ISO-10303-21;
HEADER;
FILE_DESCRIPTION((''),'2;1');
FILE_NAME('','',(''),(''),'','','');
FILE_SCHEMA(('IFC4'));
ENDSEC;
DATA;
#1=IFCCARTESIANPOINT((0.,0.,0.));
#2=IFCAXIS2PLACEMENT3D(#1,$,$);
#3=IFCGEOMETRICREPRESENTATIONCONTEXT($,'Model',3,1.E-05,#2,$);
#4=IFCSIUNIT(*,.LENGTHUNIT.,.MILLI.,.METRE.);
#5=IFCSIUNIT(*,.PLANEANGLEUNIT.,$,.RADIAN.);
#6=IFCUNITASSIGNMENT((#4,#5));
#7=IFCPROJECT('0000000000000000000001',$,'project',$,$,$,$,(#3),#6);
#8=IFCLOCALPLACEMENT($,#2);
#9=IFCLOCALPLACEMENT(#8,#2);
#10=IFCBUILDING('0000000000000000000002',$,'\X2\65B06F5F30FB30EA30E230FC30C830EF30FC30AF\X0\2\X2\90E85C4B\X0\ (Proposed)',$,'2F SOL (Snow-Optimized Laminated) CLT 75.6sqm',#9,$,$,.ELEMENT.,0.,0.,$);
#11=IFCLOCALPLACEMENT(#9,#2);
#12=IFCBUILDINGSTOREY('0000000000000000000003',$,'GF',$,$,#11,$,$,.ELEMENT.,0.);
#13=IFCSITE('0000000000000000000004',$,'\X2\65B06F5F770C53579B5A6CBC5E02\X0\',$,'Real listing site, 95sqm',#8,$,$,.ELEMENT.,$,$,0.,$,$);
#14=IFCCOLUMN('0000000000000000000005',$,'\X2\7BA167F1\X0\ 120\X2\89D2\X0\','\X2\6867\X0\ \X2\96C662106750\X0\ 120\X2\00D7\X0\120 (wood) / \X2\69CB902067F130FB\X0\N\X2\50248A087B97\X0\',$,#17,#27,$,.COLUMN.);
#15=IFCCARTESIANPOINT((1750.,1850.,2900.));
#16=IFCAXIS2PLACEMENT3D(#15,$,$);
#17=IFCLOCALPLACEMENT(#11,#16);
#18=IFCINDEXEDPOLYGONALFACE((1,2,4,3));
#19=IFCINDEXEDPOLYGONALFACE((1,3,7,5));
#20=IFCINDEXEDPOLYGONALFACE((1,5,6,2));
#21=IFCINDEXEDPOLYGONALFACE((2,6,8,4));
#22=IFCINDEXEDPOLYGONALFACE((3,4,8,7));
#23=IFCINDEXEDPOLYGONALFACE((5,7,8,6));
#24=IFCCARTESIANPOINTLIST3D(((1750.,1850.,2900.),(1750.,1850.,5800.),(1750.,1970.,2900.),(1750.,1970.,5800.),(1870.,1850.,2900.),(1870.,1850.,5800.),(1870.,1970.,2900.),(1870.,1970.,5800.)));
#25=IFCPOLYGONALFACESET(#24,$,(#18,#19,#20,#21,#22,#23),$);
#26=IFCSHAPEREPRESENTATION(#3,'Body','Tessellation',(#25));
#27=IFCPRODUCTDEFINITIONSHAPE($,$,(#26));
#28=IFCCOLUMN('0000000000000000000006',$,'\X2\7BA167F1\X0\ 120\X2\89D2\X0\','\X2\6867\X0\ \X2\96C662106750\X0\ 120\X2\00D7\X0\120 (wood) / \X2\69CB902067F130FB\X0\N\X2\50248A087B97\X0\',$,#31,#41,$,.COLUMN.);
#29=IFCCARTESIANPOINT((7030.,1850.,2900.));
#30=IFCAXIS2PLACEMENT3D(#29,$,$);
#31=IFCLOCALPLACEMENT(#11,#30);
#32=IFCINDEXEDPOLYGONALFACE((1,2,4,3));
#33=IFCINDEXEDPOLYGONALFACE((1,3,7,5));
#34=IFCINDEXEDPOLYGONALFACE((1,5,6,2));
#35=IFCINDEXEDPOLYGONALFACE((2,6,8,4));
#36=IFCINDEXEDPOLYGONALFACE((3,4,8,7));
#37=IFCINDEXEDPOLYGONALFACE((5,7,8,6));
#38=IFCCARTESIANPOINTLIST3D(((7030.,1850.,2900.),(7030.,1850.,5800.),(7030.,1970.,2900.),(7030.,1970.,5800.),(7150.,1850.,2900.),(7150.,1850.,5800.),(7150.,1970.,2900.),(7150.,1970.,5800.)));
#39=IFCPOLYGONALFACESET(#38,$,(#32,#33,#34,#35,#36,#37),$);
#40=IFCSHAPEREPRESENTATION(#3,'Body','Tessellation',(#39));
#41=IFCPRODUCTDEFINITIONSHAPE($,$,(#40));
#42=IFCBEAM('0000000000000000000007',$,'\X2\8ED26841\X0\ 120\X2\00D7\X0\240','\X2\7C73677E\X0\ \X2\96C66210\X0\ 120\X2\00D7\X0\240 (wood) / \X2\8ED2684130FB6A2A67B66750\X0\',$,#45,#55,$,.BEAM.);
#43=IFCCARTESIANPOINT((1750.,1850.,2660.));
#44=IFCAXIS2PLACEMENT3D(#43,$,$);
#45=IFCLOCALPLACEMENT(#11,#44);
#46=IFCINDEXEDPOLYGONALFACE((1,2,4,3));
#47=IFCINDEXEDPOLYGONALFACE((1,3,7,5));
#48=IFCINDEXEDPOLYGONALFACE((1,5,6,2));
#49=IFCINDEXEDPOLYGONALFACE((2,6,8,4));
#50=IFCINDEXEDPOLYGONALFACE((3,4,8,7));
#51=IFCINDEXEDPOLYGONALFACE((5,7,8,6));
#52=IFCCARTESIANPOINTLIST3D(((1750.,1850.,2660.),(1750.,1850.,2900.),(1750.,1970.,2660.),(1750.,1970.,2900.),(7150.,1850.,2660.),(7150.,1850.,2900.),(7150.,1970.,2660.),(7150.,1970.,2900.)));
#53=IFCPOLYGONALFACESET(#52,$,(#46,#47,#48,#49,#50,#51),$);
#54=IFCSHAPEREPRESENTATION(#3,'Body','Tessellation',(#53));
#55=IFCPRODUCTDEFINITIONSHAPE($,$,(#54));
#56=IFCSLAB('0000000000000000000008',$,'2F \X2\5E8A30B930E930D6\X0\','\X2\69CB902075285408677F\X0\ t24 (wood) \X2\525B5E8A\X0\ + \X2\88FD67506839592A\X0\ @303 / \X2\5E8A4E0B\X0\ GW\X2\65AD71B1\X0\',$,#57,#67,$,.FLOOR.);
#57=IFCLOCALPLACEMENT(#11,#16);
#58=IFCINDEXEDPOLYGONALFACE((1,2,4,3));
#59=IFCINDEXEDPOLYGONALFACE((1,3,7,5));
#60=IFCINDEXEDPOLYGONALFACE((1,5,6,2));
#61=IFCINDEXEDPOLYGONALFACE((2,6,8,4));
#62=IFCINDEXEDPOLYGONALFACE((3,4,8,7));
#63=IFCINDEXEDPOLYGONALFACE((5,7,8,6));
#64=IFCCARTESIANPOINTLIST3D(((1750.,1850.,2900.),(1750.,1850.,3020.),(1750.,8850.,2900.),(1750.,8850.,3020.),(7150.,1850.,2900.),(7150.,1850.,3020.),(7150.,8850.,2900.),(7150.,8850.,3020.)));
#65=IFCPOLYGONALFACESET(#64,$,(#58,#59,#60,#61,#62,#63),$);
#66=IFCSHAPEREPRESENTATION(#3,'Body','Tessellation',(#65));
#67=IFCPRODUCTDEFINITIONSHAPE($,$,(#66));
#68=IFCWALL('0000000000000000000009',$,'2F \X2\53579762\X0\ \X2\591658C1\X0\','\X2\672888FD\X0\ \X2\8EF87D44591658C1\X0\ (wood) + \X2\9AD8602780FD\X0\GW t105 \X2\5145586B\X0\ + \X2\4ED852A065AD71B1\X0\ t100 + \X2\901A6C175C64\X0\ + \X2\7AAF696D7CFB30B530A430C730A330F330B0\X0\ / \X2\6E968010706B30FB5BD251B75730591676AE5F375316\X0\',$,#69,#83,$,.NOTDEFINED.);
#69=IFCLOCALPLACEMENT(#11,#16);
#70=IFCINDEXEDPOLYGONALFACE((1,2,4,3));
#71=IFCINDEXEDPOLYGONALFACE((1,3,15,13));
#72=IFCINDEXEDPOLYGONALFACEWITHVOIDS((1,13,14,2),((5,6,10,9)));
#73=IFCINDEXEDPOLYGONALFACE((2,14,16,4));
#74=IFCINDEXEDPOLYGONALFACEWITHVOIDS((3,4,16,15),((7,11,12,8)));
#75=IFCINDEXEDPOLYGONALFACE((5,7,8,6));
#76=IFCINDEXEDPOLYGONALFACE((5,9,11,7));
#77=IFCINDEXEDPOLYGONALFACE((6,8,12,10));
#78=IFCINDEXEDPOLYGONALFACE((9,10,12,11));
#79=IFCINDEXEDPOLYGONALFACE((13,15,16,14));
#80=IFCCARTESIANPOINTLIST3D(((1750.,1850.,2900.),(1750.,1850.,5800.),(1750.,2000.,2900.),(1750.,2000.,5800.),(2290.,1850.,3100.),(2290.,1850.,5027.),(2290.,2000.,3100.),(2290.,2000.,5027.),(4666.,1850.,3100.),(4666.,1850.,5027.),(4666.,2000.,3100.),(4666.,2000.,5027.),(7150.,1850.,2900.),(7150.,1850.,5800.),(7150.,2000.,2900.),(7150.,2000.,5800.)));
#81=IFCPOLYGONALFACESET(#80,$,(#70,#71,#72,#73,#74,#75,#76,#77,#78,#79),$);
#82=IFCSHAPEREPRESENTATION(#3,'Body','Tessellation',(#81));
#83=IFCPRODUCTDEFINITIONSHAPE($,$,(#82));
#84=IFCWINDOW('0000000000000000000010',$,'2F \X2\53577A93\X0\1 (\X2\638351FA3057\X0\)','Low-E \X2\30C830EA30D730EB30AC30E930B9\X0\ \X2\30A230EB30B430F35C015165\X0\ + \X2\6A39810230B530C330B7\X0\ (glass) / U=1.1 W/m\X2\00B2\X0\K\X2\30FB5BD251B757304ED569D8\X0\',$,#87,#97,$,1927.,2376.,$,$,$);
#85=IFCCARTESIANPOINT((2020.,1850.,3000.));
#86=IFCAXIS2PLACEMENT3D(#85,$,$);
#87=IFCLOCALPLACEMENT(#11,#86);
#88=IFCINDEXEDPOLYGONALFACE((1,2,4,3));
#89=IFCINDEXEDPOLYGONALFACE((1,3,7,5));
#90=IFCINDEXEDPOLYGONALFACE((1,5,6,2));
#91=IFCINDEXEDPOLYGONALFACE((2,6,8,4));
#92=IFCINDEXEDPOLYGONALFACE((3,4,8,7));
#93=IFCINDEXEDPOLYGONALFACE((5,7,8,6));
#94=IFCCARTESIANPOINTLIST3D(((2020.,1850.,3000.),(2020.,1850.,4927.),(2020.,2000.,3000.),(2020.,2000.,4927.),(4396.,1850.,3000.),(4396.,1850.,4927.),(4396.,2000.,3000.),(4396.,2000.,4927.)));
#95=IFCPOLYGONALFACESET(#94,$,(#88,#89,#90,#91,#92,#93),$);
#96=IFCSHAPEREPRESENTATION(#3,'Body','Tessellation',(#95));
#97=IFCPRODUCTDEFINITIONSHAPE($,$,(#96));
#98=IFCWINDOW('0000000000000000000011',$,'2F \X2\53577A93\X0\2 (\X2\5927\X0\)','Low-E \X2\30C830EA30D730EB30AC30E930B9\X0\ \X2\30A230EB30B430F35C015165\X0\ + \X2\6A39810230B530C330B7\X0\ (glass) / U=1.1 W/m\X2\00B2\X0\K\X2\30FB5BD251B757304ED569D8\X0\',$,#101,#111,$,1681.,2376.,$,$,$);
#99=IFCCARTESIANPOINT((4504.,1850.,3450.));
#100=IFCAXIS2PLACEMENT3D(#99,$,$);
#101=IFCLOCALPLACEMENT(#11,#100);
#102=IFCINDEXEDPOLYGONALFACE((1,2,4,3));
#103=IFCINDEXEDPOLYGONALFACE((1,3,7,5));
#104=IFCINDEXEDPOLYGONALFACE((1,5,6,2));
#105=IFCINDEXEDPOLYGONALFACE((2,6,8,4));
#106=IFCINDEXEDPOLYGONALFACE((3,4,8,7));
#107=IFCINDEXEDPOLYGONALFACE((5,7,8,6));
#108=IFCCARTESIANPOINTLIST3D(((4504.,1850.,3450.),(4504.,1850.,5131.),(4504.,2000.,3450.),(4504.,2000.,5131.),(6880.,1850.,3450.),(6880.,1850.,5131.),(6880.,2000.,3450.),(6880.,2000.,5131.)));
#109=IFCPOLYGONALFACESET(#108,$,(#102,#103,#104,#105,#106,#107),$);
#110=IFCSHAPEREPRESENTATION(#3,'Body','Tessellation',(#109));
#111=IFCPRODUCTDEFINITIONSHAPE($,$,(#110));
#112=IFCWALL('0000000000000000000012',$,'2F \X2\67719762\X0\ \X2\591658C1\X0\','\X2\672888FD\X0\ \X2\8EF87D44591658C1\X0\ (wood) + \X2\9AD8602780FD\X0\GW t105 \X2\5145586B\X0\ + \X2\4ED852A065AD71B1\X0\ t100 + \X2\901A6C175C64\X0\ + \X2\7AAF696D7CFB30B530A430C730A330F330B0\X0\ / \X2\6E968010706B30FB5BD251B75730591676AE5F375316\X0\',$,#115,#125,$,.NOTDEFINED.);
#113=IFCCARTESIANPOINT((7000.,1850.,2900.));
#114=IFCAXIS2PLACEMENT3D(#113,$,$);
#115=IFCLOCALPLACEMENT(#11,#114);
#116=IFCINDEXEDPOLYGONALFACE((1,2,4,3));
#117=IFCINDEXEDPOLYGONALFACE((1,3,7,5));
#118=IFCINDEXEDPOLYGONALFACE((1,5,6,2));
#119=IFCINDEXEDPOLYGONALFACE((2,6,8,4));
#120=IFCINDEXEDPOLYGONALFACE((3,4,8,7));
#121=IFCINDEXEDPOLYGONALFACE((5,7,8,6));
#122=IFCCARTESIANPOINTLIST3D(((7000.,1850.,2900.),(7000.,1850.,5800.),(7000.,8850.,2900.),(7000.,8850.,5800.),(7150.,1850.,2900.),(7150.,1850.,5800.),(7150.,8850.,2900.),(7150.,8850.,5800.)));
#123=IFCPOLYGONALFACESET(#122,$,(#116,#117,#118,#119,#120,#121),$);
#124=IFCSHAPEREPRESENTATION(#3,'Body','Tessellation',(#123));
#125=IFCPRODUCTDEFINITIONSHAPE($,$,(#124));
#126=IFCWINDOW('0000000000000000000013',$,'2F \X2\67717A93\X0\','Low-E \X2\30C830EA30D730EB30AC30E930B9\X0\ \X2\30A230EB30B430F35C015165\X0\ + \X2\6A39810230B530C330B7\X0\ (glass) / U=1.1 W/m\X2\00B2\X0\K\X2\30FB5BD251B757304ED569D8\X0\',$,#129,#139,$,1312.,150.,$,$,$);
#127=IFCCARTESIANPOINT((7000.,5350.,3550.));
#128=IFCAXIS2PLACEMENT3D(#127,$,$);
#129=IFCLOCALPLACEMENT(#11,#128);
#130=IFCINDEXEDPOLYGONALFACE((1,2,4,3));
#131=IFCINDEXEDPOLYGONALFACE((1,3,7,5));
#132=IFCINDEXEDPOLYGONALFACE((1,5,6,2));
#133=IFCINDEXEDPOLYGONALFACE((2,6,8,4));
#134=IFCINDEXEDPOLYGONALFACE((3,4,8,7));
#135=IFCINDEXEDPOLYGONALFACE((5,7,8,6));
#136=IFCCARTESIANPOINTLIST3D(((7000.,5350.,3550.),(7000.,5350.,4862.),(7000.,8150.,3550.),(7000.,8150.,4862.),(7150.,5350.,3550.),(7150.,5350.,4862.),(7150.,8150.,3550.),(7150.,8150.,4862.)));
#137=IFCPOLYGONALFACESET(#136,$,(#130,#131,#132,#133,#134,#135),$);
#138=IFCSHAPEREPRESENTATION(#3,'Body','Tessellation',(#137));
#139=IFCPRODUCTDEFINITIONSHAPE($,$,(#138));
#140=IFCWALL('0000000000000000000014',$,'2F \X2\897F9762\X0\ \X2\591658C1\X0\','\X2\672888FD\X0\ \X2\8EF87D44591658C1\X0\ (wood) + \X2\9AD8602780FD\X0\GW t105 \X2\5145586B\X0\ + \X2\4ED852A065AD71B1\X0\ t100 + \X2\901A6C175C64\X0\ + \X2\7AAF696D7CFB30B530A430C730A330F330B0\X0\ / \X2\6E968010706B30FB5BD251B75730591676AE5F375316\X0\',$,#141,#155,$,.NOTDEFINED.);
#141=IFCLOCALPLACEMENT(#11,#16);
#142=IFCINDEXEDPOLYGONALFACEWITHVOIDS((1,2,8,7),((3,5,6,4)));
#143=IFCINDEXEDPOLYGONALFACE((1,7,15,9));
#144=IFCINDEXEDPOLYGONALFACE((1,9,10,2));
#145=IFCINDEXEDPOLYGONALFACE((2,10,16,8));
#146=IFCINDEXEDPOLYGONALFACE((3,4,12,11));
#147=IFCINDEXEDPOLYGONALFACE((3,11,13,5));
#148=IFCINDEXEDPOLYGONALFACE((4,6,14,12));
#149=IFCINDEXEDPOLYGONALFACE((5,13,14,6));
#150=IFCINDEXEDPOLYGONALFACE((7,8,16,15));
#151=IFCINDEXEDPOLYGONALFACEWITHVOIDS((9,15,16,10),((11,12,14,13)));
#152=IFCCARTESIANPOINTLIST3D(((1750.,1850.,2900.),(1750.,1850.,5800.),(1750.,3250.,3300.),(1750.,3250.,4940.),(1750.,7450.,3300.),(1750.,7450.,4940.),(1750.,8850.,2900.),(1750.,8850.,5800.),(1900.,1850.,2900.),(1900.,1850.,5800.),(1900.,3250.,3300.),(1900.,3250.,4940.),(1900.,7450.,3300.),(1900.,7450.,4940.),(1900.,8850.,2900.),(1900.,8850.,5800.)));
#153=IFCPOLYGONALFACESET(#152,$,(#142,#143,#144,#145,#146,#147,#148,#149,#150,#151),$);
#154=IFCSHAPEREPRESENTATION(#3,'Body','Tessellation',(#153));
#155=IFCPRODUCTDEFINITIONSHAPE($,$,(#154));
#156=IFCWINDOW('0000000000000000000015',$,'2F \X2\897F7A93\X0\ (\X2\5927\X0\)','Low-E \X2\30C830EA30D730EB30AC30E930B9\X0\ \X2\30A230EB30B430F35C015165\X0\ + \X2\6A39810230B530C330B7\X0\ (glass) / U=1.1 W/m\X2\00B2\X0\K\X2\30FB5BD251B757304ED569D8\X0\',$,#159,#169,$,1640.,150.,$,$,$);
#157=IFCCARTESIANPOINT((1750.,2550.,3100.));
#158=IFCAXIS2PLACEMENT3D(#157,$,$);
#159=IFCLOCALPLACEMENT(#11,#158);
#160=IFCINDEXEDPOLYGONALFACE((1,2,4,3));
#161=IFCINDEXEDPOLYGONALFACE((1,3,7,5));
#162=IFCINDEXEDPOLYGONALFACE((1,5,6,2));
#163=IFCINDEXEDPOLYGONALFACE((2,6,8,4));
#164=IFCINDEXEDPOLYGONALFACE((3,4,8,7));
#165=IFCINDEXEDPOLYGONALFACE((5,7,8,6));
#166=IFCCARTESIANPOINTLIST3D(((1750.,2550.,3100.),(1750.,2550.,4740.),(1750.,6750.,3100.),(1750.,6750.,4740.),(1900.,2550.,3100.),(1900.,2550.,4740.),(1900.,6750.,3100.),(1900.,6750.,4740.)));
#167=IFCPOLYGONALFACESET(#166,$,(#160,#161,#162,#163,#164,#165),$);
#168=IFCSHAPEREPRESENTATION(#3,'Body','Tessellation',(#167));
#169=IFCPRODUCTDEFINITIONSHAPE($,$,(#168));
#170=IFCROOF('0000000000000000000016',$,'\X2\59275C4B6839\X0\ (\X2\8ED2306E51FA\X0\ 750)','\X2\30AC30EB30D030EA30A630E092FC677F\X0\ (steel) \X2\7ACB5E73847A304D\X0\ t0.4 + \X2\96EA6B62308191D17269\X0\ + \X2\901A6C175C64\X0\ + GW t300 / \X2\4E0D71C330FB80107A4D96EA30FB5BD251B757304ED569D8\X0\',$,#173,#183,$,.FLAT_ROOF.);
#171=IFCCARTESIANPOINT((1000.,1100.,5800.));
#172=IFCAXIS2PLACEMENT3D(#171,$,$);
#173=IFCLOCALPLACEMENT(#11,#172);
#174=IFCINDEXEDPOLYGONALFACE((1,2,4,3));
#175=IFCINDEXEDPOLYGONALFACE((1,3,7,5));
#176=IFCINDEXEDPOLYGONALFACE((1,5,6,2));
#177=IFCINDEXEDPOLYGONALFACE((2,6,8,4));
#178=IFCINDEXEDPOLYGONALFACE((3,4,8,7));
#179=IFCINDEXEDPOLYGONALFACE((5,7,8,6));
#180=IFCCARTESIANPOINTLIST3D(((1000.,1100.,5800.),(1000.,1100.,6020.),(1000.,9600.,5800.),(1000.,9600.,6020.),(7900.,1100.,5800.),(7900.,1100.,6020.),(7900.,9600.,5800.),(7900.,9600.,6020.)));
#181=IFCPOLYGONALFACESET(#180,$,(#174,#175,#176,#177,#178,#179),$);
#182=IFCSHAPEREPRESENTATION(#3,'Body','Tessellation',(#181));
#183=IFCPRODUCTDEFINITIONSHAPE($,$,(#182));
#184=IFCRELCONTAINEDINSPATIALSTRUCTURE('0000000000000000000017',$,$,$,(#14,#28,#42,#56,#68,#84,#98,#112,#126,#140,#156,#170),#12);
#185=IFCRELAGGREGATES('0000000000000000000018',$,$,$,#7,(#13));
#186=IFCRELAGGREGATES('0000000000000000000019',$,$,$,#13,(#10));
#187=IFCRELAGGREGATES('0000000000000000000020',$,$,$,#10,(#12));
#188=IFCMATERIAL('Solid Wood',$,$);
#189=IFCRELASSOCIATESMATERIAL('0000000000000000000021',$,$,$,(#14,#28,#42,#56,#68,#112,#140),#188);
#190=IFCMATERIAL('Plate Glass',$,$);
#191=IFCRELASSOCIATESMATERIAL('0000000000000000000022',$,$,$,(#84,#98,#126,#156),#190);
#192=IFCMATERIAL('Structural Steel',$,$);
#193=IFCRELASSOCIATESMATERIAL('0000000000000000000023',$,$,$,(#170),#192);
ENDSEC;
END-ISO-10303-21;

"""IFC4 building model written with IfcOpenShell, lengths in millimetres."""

from ifc_helpers import new_model, si_unit, frame, frame_2d, origin, place, context, project, spatial, rectangle, extrude, material, element, fill, save


model = new_model("IFC4")

# Units and contexts
model_context = context("Model", 3, precision=1e-05, world=origin())
ifc_project = project(units=[si_unit("LENGTHUNIT", "METRE", prefix="MILLI"), si_unit("PLANEANGLEUNIT", "RADIAN")], contexts=[model_context])

# Site, building, storey
site_placement = place(None, origin())
site = spatial("IfcSite", under=ifc_project, at=site_placement, Name="新潟県南魚沼市", ObjectType="Real listing site, 95sqm", CompositionType="ELEMENT", RefElevation=0.0)
building_placement = place(site_placement, origin())
building = spatial("IfcBuilding", under=site, at=building_placement, Name="新潟・リモートワーク2部屋 (Proposed)", ObjectType="2F SOL (Snow-Optimized Laminated) CLT 75.6sqm", CompositionType="ELEMENT", ElevationOfRefHeight=0.0, ElevationOfTerrain=0.0)
storey_placement = place(building_placement, origin())
storey = spatial("IfcBuildingStorey", under=building, at=storey_placement, Name="GF", CompositionType="ELEMENT", Elevation=0.0)

# Columns
ifc_material_1 = material(Name="Solid Wood")
column_1_placement = place(storey_placement, frame((1750.0, 1850.0, 2900.0)))
element("IfcColumn", 1, at=column_1_placement, inside=storey, material=ifc_material_1, Name="管柱 120角", Description="桧 集成材 120×120 (wood) / 構造柱・N値計算", PredefinedType="COLUMN", context=model_context, shape_type="SweptSolid", body=[
    extrude(rectangle(XDim=120.0, YDim=120.0, at=frame_2d((60.0, 60.0))), frame((1750.0, 1850.0, 2900.0)), (0.0, 0.0, 1.0), 2900.0),
])
column_2_placement = place(storey_placement, frame((7030.0, 1850.0, 2900.0)))
element("IfcColumn", 2, at=column_2_placement, inside=storey, material=ifc_material_1, Name="管柱 120角", Description="桧 集成材 120×120 (wood) / 構造柱・N値計算", PredefinedType="COLUMN", context=model_context, shape_type="SweptSolid", body=[
    extrude(rectangle(XDim=120.0, YDim=120.0, at=frame_2d((60.0, 60.0))), frame((7030.0, 1850.0, 2900.0)), (0.0, 0.0, 1.0), 2900.0),
])

# Beam
beam_1_placement = place(storey_placement, frame((1750.0, 1850.0, 2660.0)))
element("IfcBeam", 3, at=beam_1_placement, inside=storey, material=ifc_material_1, Name="軒桁 120×240", Description="米松 集成 120×240 (wood) / 軒桁・横架材", PredefinedType="BEAM", context=model_context, shape_type="SweptSolid", body=[
    extrude(rectangle(XDim=5400.0, YDim=120.0, at=frame_2d((2700.0, 60.0))), frame((1750.0, 1850.0, 2660.0)), (0.0, 0.0, 1.0), 240.0),
])

# Slab
slab_placement = place(storey_placement, frame((1750.0, 1850.0, 2900.0)))
element("IfcSlab", 4, at=slab_placement, inside=storey, material=ifc_material_1, Name="2F 床スラブ", Description="構造用合板 t24 (wood) 剛床 + 製材根太 @303 / 床下 GW断熱", PredefinedType="FLOOR", context=model_context, shape_type="SweptSolid", body=[
    extrude(rectangle(XDim=5400.0, YDim=7000.0, at=frame_2d((2700.0, 3500.0))), frame((1750.0, 1850.0, 2900.0)), (0.0, 0.0, 1.0), 120.0),
])

# Wall, openings, windows
wall_1_placement = place(storey_placement, frame((1750.0, 1850.0, 2900.0)))
wall_1 = element("IfcWall", 5, at=wall_1_placement, inside=storey, material=ifc_material_1, Name="2F 南面 外壁", Description="木製 軸組外壁 (wood) + 高性能GW t105 充填 + 付加断熱 t100 + 通気層 + 窯業系サイディング / 準耐火・寒冷地外皮強化", PredefinedType="NOTDEFINED", context=model_context, shape_type="SweptSolid", body=[
    extrude(rectangle(XDim=5400.0, YDim=150.0, at=frame_2d((2700.0, 75.0))), frame((1750.0, 1850.0, 2900.0)), (0.0, 0.0, 1.0), 2900.0),
])
opening_1_placement = place(storey_placement, frame((2020.0, 1850.0, 3000.0)))
opening_1 = element("IfcOpeningElement", 6, at=opening_1_placement, cuts=wall_1, PredefinedType="NOTDEFINED", context=model_context, shape_type="SweptSolid", body=[
    extrude(rectangle(XDim=2376.0, YDim=150.0, at=frame_2d((1188.0, 75.0))), frame((2020.0, 1850.0, 3000.0)), (0.0, 0.0, 1.0), 1927.0),
])
opening_2_placement = place(storey_placement, frame((4504.0, 1850.0, 3450.0)))
opening_2 = element("IfcOpeningElement", 7, at=opening_2_placement, cuts=wall_1, PredefinedType="NOTDEFINED", context=model_context, shape_type="SweptSolid", body=[
    extrude(rectangle(XDim=2376.0, YDim=150.0, at=frame_2d((1188.0, 75.0))), frame((4504.0, 1850.0, 3450.0)), (0.0, 0.0, 1.0), 1681.0),
])
ifc_material_2 = material(Name="Plate Glass")
window_1_placement = place(storey_placement, frame((2020.0, 1850.0, 3000.0)))
window_1 = element("IfcWindow", 8, at=window_1_placement, inside=storey, material=ifc_material_2, Name="2F 南窓1 (掃出し)", Description="Low-E トリプルガラス アルゴン封入 + 樹脂サッシ (glass) / U=1.1 W/m²K・寒冷地仕様", OverallHeight=1927.0, OverallWidth=2376.0, context=model_context, shape_type="SweptSolid", body=[
    extrude(rectangle(XDim=2376.0, YDim=150.0, at=frame_2d((1188.0, 75.0))), frame((2020.0, 1850.0, 3000.0)), (0.0, 0.0, 1.0), 1927.0),
])
fill(opening_1, window_1)
window_2_placement = place(storey_placement, frame((4504.0, 1850.0, 3450.0)))
window_2 = element("IfcWindow", 9, at=window_2_placement, inside=storey, material=ifc_material_2, Name="2F 南窓2 (大)", Description="Low-E トリプルガラス アルゴン封入 + 樹脂サッシ (glass) / U=1.1 W/m²K・寒冷地仕様", OverallHeight=1681.0, OverallWidth=2376.0, context=model_context, shape_type="SweptSolid", body=[
    extrude(rectangle(XDim=2376.0, YDim=150.0, at=frame_2d((1188.0, 75.0))), frame((4504.0, 1850.0, 3450.0)), (0.0, 0.0, 1.0), 1681.0),
])
fill(opening_2, window_2)

# Walls, openings, windows
wall_2_placement = place(storey_placement, frame((7000.0, 1850.0, 2900.0)))
wall_2 = element("IfcWall", 10, at=wall_2_placement, inside=storey, material=ifc_material_1, Name="2F 東面 外壁", Description="木製 軸組外壁 (wood) + 高性能GW t105 充填 + 付加断熱 t100 + 通気層 + 窯業系サイディング / 準耐火・寒冷地外皮強化", PredefinedType="NOTDEFINED", context=model_context, shape_type="SweptSolid", body=[
    extrude(rectangle(XDim=150.0, YDim=7000.0, at=frame_2d((75.0, 3500.0))), frame((7000.0, 1850.0, 2900.0)), (0.0, 0.0, 1.0), 2900.0),
])
opening_3_placement = place(storey_placement, frame((7000.0, 5350.0, 3550.0)))
opening_3 = element("IfcOpeningElement", 11, at=opening_3_placement, cuts=wall_2, PredefinedType="NOTDEFINED", context=model_context, shape_type="SweptSolid", body=[
    extrude(rectangle(XDim=150.0, YDim=2800.0, at=frame_2d((75.0, 1400.0))), frame((7000.0, 5350.0, 3550.0)), (0.0, 0.0, 1.0), 1312.0),
])
window_3_placement = place(storey_placement, frame((7000.0, 5350.0, 3550.0)))
window_3 = element("IfcWindow", 12, at=window_3_placement, inside=storey, material=ifc_material_2, Name="2F 東窓", Description="Low-E トリプルガラス アルゴン封入 + 樹脂サッシ (glass) / U=1.1 W/m²K・寒冷地仕様", OverallHeight=1312.0, OverallWidth=150.0, context=model_context, shape_type="SweptSolid", body=[
    extrude(rectangle(XDim=150.0, YDim=2800.0, at=frame_2d((75.0, 1400.0))), frame((7000.0, 5350.0, 3550.0)), (0.0, 0.0, 1.0), 1312.0),
])
fill(opening_3, window_3)
wall_3_placement = place(storey_placement, frame((1750.0, 1850.0, 2900.0)))
wall_3 = element("IfcWall", 13, at=wall_3_placement, inside=storey, material=ifc_material_1, Name="2F 西面 外壁", Description="木製 軸組外壁 (wood) + 高性能GW t105 充填 + 付加断熱 t100 + 通気層 + 窯業系サイディング / 準耐火・寒冷地外皮強化", PredefinedType="NOTDEFINED", context=model_context, shape_type="SweptSolid", body=[
    extrude(rectangle(XDim=150.0, YDim=7000.0, at=frame_2d((75.0, 3500.0))), frame((1750.0, 1850.0, 2900.0)), (0.0, 0.0, 1.0), 2900.0),
])
opening_4_placement = place(storey_placement, frame((1750.0, 2550.0, 3100.0)))
opening_4 = element("IfcOpeningElement", 14, at=opening_4_placement, cuts=wall_3, PredefinedType="NOTDEFINED", context=model_context, shape_type="SweptSolid", body=[
    extrude(rectangle(XDim=150.0, YDim=4200.0, at=frame_2d((75.0, 2100.0))), frame((1750.0, 2550.0, 3100.0)), (0.0, 0.0, 1.0), 1640.0),
])
window_4_placement = place(storey_placement, frame((1750.0, 2550.0, 3100.0)))
window_4 = element("IfcWindow", 15, at=window_4_placement, inside=storey, material=ifc_material_2, Name="2F 西窓 (大)", Description="Low-E トリプルガラス アルゴン封入 + 樹脂サッシ (glass) / U=1.1 W/m²K・寒冷地仕様", OverallHeight=1640.0, OverallWidth=150.0, context=model_context, shape_type="SweptSolid", body=[
    extrude(rectangle(XDim=150.0, YDim=4200.0, at=frame_2d((75.0, 2100.0))), frame((1750.0, 2550.0, 3100.0)), (0.0, 0.0, 1.0), 1640.0),
])
fill(opening_4, window_4)

# Roof
ifc_material_3 = material(Name="Structural Steel")
roof_placement = place(storey_placement, frame((1000.0, 1100.0, 5800.0)))
element("IfcRoof", 16, at=roof_placement, inside=storey, material=ifc_material_3, Name="大屋根 (軒の出 750)", Description="ガルバリウム鋼板 (steel) 立平葺き t0.4 + 雪止め金物 + 通気層 + GW t300 / 不燃・耐積雪・寒冷地仕様", PredefinedType="FLAT_ROOF", context=model_context, shape_type="SweptSolid", body=[
    extrude(rectangle(XDim=6900.0, YDim=8500.0, at=frame_2d((3450.0, 4250.0))), frame((1000.0, 1100.0, 5800.0)), (0.0, 0.0, 1.0), 220.0),
])

save(model, "model.ifc")
